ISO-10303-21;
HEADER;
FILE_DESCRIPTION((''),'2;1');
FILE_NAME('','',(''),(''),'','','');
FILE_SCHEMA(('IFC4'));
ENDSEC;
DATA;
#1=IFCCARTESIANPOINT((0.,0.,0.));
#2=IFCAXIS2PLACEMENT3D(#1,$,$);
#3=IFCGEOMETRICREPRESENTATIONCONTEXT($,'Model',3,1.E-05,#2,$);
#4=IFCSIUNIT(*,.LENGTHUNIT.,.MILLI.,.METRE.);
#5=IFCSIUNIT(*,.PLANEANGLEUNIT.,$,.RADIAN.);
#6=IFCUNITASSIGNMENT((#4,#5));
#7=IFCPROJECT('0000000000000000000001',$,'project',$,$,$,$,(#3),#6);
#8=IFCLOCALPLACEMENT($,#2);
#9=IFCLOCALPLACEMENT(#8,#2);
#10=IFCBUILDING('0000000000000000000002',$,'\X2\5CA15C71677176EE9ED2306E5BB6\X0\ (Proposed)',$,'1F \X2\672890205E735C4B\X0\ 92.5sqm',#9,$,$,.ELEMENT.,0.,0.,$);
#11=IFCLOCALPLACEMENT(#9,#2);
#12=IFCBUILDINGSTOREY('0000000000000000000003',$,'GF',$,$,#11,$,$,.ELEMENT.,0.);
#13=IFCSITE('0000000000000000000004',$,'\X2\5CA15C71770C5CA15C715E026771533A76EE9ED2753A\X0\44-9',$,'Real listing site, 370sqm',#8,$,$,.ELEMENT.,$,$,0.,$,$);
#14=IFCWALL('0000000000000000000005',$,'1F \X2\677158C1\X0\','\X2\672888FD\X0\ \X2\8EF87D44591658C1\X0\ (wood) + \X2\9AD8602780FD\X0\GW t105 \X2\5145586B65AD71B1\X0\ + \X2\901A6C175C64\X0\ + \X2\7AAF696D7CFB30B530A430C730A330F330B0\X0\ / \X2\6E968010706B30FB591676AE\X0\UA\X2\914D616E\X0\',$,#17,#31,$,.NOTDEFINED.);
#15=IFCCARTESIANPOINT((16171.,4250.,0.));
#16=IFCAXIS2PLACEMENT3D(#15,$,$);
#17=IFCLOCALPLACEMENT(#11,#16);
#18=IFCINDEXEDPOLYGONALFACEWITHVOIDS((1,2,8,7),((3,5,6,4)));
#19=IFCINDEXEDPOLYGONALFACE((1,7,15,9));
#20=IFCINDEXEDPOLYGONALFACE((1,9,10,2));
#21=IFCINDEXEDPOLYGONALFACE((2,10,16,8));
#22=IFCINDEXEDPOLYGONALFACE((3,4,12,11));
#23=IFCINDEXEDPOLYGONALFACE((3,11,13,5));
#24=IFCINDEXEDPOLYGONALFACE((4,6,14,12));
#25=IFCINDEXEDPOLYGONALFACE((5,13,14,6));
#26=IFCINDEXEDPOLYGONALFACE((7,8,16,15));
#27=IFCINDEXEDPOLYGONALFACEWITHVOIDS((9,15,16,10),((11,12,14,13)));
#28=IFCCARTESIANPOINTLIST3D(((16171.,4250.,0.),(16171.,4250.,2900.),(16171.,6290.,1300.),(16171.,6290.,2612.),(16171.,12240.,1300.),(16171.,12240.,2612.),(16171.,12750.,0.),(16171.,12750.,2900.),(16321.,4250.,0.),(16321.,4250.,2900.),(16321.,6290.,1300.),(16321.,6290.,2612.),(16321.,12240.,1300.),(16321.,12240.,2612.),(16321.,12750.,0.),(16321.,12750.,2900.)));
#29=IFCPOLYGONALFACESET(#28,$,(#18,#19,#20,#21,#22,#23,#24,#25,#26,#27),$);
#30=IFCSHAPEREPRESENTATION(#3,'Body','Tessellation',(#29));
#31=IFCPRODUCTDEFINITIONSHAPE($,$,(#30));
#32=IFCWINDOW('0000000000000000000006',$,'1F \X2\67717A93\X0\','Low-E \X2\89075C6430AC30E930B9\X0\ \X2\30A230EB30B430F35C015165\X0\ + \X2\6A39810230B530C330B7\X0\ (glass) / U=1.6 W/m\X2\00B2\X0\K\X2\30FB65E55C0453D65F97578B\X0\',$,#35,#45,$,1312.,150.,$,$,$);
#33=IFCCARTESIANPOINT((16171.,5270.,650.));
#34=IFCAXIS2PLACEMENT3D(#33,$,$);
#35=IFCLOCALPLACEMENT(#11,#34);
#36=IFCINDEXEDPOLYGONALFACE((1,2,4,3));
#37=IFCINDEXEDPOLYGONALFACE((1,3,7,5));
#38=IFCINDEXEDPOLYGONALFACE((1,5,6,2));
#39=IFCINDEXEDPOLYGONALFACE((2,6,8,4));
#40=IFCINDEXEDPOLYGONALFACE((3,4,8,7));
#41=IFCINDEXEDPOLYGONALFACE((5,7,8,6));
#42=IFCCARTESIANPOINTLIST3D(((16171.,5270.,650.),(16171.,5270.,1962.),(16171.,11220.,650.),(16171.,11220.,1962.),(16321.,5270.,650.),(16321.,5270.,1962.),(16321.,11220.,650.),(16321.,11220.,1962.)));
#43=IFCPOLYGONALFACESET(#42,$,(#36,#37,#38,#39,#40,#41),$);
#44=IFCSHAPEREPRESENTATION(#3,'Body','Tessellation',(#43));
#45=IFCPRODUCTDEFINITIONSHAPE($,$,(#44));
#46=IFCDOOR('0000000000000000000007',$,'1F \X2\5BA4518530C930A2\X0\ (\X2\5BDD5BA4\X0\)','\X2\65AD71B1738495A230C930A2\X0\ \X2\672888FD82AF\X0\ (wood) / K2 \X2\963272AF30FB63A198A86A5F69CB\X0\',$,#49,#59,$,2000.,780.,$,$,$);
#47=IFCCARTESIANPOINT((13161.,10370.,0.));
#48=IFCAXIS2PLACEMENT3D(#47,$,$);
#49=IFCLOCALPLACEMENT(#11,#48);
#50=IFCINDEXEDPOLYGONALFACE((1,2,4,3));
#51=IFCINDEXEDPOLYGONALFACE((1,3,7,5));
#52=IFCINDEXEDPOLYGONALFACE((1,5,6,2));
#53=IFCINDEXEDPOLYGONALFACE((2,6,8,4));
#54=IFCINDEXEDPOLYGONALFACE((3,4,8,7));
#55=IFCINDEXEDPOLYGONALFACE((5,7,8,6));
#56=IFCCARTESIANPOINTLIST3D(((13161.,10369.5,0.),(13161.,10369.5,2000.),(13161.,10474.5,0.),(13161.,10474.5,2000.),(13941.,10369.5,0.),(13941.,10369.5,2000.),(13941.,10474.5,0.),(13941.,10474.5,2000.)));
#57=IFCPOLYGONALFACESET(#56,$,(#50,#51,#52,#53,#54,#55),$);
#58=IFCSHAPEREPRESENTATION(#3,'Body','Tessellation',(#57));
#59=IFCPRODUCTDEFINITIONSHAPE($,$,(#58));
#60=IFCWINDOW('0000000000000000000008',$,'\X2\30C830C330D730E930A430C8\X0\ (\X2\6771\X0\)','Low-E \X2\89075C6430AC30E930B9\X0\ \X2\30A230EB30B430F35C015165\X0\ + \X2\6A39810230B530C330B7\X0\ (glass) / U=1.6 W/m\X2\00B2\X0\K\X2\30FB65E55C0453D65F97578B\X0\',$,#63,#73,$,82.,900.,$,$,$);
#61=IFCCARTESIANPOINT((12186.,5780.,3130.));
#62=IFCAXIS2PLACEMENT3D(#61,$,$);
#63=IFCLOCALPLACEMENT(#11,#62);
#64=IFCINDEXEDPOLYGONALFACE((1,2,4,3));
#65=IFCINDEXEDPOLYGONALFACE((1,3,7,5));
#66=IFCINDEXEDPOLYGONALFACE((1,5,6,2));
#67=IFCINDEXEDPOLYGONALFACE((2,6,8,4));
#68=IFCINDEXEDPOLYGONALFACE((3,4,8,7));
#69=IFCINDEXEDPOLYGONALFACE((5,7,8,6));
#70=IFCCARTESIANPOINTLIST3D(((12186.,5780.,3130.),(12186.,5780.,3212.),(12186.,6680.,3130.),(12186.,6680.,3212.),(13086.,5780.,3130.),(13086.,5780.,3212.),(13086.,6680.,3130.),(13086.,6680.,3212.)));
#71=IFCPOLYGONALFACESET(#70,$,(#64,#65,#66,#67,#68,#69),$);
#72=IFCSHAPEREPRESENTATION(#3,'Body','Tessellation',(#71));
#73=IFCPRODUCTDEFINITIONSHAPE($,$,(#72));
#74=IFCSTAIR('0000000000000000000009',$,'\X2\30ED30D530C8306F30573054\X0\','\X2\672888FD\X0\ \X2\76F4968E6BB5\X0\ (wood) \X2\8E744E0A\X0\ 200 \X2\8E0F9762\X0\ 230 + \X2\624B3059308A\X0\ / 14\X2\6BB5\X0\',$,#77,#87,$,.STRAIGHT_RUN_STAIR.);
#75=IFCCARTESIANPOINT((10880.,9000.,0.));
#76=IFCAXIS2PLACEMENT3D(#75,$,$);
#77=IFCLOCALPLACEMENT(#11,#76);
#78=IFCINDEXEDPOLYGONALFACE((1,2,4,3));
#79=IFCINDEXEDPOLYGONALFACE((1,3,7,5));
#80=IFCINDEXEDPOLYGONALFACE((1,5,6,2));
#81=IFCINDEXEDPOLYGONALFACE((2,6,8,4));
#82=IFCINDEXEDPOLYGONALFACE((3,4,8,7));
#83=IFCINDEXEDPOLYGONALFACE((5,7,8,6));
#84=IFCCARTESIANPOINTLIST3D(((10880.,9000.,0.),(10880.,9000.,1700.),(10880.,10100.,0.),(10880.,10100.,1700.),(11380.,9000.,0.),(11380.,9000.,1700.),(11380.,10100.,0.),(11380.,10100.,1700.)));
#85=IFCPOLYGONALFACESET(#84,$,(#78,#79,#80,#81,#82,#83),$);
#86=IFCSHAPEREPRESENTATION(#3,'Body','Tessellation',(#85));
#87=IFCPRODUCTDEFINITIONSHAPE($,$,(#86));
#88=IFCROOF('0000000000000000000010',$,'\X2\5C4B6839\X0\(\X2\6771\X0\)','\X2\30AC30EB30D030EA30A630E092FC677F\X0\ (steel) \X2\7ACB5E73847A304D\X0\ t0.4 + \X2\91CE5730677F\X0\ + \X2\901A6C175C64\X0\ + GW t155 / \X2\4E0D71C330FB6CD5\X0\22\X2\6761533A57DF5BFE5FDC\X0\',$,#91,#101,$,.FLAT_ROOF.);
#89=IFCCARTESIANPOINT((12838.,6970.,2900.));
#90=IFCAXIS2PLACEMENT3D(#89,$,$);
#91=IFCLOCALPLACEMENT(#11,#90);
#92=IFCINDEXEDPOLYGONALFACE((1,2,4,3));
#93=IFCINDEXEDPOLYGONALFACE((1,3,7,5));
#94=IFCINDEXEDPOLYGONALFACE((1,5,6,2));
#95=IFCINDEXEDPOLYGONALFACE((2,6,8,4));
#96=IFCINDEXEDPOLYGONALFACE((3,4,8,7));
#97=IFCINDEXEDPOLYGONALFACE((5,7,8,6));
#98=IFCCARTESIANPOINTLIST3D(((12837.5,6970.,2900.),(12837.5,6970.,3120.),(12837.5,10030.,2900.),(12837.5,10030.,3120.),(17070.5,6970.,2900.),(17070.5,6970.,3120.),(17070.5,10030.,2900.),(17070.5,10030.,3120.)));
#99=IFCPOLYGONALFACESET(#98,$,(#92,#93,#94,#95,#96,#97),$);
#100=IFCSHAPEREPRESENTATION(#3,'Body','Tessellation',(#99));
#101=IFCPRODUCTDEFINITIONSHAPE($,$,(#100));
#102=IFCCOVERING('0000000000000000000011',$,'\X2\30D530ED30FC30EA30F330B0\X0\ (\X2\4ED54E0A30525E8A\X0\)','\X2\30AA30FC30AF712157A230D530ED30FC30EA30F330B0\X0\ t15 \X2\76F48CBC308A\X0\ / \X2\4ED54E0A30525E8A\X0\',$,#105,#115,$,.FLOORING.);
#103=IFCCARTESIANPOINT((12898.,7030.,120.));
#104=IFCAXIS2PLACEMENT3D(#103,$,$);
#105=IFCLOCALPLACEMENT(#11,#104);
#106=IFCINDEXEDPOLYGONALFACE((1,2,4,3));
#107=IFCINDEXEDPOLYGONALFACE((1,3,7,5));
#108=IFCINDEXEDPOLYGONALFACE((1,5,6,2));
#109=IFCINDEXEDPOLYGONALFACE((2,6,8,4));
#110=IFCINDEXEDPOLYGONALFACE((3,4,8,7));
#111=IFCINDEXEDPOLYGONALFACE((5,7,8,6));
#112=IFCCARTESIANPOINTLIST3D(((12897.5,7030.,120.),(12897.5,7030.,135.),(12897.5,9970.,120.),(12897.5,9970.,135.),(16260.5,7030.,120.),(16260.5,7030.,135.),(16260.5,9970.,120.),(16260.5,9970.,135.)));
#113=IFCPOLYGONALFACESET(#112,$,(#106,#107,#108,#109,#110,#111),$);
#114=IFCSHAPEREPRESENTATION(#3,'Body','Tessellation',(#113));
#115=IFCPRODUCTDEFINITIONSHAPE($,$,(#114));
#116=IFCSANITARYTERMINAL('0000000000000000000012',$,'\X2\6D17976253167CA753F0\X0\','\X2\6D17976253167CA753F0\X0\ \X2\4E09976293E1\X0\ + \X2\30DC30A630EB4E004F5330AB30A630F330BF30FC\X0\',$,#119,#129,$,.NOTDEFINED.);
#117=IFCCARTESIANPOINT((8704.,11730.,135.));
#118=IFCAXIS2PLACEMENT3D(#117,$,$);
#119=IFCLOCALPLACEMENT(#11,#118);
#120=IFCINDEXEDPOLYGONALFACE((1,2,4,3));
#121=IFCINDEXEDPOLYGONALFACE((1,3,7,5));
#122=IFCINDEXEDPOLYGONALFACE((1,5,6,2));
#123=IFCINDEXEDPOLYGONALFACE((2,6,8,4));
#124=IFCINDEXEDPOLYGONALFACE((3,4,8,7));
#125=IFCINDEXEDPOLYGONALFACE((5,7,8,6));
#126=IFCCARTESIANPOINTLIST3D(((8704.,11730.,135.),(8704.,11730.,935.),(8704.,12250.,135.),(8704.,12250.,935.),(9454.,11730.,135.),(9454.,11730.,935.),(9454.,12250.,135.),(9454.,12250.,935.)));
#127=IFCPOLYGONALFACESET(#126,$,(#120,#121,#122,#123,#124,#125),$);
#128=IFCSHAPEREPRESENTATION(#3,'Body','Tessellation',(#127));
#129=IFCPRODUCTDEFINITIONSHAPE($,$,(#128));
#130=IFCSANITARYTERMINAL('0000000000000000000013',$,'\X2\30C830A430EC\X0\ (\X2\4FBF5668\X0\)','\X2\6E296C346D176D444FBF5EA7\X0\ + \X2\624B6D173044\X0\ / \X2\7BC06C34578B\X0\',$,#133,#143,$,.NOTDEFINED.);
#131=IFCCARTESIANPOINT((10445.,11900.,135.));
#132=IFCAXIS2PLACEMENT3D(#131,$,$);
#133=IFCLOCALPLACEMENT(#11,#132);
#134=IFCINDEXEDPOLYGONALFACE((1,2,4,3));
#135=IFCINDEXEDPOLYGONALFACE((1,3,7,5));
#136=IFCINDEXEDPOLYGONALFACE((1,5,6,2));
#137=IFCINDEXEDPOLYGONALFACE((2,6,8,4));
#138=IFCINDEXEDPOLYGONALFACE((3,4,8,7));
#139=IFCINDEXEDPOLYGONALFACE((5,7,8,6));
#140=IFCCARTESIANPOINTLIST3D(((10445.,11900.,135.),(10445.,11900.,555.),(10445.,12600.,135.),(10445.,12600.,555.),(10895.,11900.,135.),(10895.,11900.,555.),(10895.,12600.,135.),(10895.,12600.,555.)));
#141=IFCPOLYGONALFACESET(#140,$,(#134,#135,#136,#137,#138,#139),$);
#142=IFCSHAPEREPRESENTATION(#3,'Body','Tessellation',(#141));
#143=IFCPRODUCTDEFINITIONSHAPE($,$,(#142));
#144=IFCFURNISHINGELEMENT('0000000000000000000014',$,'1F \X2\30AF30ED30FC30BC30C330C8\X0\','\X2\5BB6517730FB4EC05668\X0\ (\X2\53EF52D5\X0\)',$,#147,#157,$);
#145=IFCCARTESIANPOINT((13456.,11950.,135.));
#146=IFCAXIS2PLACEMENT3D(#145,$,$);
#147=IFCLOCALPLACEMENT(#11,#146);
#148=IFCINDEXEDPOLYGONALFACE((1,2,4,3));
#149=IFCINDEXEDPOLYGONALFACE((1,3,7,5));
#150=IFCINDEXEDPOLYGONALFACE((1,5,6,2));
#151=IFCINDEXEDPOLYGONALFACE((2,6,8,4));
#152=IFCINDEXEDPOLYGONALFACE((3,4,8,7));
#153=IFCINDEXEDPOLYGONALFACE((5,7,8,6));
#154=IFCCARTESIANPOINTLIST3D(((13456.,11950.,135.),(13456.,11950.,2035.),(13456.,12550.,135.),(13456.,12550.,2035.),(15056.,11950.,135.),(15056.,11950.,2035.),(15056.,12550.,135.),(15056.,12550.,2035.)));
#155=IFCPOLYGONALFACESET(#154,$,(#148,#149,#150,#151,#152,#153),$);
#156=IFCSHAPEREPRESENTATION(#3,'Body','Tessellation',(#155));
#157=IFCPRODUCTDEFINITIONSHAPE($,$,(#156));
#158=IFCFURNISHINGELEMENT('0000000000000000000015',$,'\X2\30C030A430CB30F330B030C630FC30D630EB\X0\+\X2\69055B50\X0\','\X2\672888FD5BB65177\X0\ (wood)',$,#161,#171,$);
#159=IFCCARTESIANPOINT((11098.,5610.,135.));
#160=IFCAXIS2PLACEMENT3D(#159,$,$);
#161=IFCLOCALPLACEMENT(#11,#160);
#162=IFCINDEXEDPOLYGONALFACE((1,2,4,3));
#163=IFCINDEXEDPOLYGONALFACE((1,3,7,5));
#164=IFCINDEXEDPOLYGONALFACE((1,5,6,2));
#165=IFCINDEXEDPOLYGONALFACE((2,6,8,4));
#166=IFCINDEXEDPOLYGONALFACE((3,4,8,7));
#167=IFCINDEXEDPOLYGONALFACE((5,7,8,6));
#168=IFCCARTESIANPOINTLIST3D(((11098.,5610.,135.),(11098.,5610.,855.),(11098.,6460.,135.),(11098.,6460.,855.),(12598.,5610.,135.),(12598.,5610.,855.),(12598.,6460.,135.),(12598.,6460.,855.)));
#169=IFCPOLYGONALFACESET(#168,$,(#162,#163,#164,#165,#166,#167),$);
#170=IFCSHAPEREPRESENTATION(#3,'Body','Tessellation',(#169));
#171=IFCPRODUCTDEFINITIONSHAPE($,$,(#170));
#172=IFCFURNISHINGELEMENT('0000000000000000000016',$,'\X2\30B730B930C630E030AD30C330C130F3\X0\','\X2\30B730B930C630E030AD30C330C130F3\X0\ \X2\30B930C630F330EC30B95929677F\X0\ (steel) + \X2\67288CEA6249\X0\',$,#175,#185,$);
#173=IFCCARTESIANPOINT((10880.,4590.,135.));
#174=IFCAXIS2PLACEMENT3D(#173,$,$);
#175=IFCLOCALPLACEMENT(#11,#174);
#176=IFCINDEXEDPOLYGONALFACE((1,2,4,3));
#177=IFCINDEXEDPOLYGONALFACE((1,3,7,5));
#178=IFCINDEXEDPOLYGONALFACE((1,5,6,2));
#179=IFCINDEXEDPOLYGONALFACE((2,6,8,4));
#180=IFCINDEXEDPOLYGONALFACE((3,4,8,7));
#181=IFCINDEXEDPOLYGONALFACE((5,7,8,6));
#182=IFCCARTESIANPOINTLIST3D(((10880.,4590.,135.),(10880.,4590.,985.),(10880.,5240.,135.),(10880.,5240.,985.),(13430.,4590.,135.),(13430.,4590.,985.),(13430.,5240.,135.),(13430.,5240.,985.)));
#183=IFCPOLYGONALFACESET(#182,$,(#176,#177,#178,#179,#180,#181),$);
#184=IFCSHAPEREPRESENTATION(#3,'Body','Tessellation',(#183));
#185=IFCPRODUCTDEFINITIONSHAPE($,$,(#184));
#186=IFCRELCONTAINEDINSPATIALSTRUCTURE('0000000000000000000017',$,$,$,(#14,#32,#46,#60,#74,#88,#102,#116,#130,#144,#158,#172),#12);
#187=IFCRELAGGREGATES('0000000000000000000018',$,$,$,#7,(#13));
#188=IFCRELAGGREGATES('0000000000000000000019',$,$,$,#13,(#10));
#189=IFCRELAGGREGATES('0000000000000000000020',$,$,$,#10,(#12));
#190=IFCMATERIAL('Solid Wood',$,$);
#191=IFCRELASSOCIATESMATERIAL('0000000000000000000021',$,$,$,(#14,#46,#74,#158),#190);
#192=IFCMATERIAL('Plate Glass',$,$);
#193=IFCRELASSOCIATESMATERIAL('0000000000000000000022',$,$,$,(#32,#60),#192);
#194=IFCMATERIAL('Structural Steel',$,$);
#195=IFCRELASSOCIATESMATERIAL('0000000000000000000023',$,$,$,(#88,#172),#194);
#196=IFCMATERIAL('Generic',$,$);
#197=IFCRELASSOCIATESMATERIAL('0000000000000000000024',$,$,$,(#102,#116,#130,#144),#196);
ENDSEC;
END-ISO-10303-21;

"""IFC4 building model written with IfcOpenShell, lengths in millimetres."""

from ifc_helpers import new_model, si_unit, frame, frame_2d, origin, place, context, project, spatial, rectangle, extrude, material, element, fill, save


model = new_model("IFC4")

# Units and contexts
model_context = context("Model", 3, precision=1e-05, world=origin())
ifc_project = project(units=[si_unit("LENGTHUNIT", "METRE", prefix="MILLI"), si_unit("PLANEANGLEUNIT", "RADIAN")], contexts=[model_context])

# Site, building, storey
site_placement = place(None, origin())
site = spatial("IfcSite", under=ifc_project, at=site_placement, Name="岡山県岡山市東区目黒町44-9", ObjectType="Real listing site, 370sqm", CompositionType="ELEMENT", RefElevation=0.0)
building_placement = place(site_placement, origin())
building = spatial("IfcBuilding", under=site, at=building_placement, Name="岡山東目黒の家 (Proposed)", ObjectType="1F 木造平屋 92.5sqm", CompositionType="ELEMENT", ElevationOfRefHeight=0.0, ElevationOfTerrain=0.0)
storey_placement = place(building_placement, origin())
storey = spatial("IfcBuildingStorey", under=building, at=storey_placement, Name="GF", CompositionType="ELEMENT", Elevation=0.0)

# Shared definitions
ifc_material_1 = material(Name="Solid Wood")

# Wall, opening, window
wall_1_placement = place(storey_placement, frame((16171.0, 4250.0, 0.0)))
wall_1 = element("IfcWall", 1, at=wall_1_placement, inside=storey, material=ifc_material_1, Name="1F 東壁", Description="木製 軸組外壁 (wood) + 高性能GW t105 充填断熱 + 通気層 + 窯業系サイディング / 準耐火・外皮UA配慮", PredefinedType="NOTDEFINED", context=model_context, shape_type="SweptSolid", body=[
    extrude(rectangle(XDim=150.0, YDim=8500.0, at=frame_2d((75.0, 4250.0))), frame((16171.0, 4250.0, 0.0)), (0.0, 0.0, 1.0), 2900.0),
])
opening_1_placement = place(storey_placement, frame((16171.0, 5270.0, 650.0)))
opening_1 = element("IfcOpeningElement", 2, at=opening_1_placement, cuts=wall_1, PredefinedType="NOTDEFINED", context=model_context, shape_type="SweptSolid", body=[
    extrude(rectangle(XDim=150.0, YDim=5950.0, at=frame_2d((75.0, 2975.0))), frame((16171.0, 5270.0, 650.0)), (0.0, 0.0, 1.0), 1312.0),
])
ifc_material_2 = material(Name="Plate Glass")
window_1_placement = place(storey_placement, frame((16171.0, 5270.0, 650.0)))
window_1 = element("IfcWindow", 3, at=window_1_placement, inside=storey, material=ifc_material_2, Name="1F 東窓", Description="Low-E 複層ガラス アルゴン封入 + 樹脂サッシ (glass) / U=1.6 W/m²K・日射取得型", OverallHeight=1312.0, OverallWidth=150.0, context=model_context, shape_type="SweptSolid", body=[
    extrude(rectangle(XDim=150.0, YDim=5950.0, at=frame_2d((75.0, 2975.0))), frame((16171.0, 5270.0, 650.0)), (0.0, 0.0, 1.0), 1312.0),
])
fill(opening_1, window_1)

# Door
door_placement = place(storey_placement, frame((13161.0, 10370.0, 0.0)))
element("IfcDoor", 4, at=door_placement, inside=storey, material=ifc_material_1, Name="1F 室内ドア (寝室)", Description="断熱玄関ドア 木製芯 (wood) / K2 防犯・採風機構", OverallHeight=2000.0, OverallWidth=780.0, context=model_context, shape_type="SweptSolid", body=[
    extrude(rectangle(XDim=780.0, YDim=105.0, at=frame_2d((390.0, 52.0))), frame((13161.0, 10370.0, 0.0)), (0.0, 0.0, 1.0), 2000.0),
])

# Window
window_2_placement = place(storey_placement, frame((12186.0, 5780.0, 3130.0)))
element("IfcWindow", 5, at=window_2_placement, inside=storey, material=ifc_material_2, Name="トップライト (東)", Description="Low-E 複層ガラス アルゴン封入 + 樹脂サッシ (glass) / U=1.6 W/m²K・日射取得型", OverallHeight=82.0, OverallWidth=900.0, context=model_context, shape_type="SweptSolid", body=[
    extrude(rectangle(XDim=900.0, YDim=900.0, at=frame_2d((450.0, 450.0))), frame((12186.0, 5780.0, 3130.0)), (0.0, 0.0, 1.0), 82.0),
])

# Stair
stair_placement = place(storey_placement, frame((10880.0, 9000.0, 0.0)))
element("IfcStair", 6, at=stair_placement, inside=storey, material=ifc_material_1, Name="ロフトはしご", Description="木製 直階段 (wood) 蹴上 200 踏面 230 + 手すり / 14段", PredefinedType="STRAIGHT_RUN_STAIR", context=model_context, shape_type="SweptSolid", body=[
    extrude(rectangle(XDim=500.0, YDim=1100.0, at=frame_2d((250.0, 550.0))), frame((10880.0, 9000.0, 0.0)), (0.0, 0.0, 1.0), 1700.0),
])

# Roof
ifc_material_3 = material(Name="Structural Steel")
roof_placement = place(storey_placement, frame((12838.0, 6970.0, 2900.0)))
element("IfcRoof", 7, at=roof_placement, inside=storey, material=ifc_material_3, Name="屋根(東)", Description="ガルバリウム鋼板 (steel) 立平葺き t0.4 + 野地板 + 通気層 + GW t155 / 不燃・法22条区域対応", PredefinedType="FLAT_ROOF", context=model_context, shape_type="SweptSolid", body=[
    extrude(rectangle(XDim=4233.0, YDim=3060.0, at=frame_2d((2116.0, 1530.0))), frame((12838.0, 6970.0, 2900.0)), (0.0, 0.0, 1.0), 220.0),
])

# Covering
ifc_material_4 = material(Name="Generic")
covering_placement = place(storey_placement, frame((12898.0, 7030.0, 120.0)))
element("IfcCovering", 8, at=covering_placement, inside=storey, material=ifc_material_4, Name="フローリング (仕上げ床)", Description="オーク無垢フローリング t15 直貼り / 仕上げ床", PredefinedType="FLOORING", context=model_context, shape_type="SweptSolid", body=[
    extrude(rectangle(XDim=3363.0, YDim=2940.0, at=frame_2d((1681.0, 1470.0))), frame((12898.0, 7030.0, 120.0)), (0.0, 0.0, 1.0), 15.0),
])

# Sanitary terminals
sanitary_terminal_1_placement = place(storey_placement, frame((8704.0, 11730.0, 135.0)))
element("IfcSanitaryTerminal", 9, at=sanitary_terminal_1_placement, inside=storey, material=ifc_material_4, Name="洗面化粧台", Description="洗面化粧台 三面鏡 + ボウル一体カウンター", PredefinedType="NOTDEFINED", context=model_context, shape_type="SweptSolid", body=[
    extrude(rectangle(XDim=750.0, YDim=520.0, at=frame_2d((375.0, 260.0))), frame((8704.0, 11730.0, 135.0)), (0.0, 0.0, 1.0), 800.0),
])
sanitary_terminal_2_placement = place(storey_placement, frame((10445.0, 11900.0, 135.0)))
element("IfcSanitaryTerminal", 10, at=sanitary_terminal_2_placement, inside=storey, material=ifc_material_4, Name="トイレ (便器)", Description="温水洗浄便座 + 手洗い / 節水型", PredefinedType="NOTDEFINED", context=model_context, shape_type="SweptSolid", body=[
    extrude(rectangle(XDim=450.0, YDim=700.0, at=frame_2d((225.0, 350.0))), frame((10445.0, 11900.0, 135.0)), (0.0, 0.0, 1.0), 420.0),
])

# Furnishing elements
furnishing_1_placement = place(storey_placement, frame((13456.0, 11950.0, 135.0)))
element("IfcFurnishingElement", 11, at=furnishing_1_placement, inside=storey, material=ifc_material_4, Name="1F クローゼット", Description="家具・什器 (可動)", context=model_context, shape_type="SweptSolid", body=[
    extrude(rectangle(XDim=1600.0, YDim=600.0, at=frame_2d((800.0, 300.0))), frame((13456.0, 11950.0, 135.0)), (0.0, 0.0, 1.0), 1900.0),
])
furnishing_2_placement = place(storey_placement, frame((11098.0, 5610.0, 135.0)))
element("IfcFurnishingElement", 12, at=furnishing_2_placement, inside=storey, material=ifc_material_1, Name="ダイニングテーブル+椅子", Description="木製家具 (wood)", context=model_context, shape_type="SweptSolid", body=[
    extrude(rectangle(XDim=1500.0, YDim=850.0, at=frame_2d((750.0, 425.0))), frame((11098.0, 5610.0, 135.0)), (0.0, 0.0, 1.0), 720.0),
])
furnishing_3_placement = place(storey_placement, frame((10880.0, 4590.0, 135.0)))
element("IfcFurnishingElement", 13, at=furnishing_3_placement, inside=storey, material=ifc_material_3, Name="システムキッチン", Description="システムキッチン ステンレス天板 (steel) + 木質扉", context=model_context, shape_type="SweptSolid", body=[
    extrude(rectangle(XDim=2550.0, YDim=650.0, at=frame_2d((1275.0, 325.0))), frame((10880.0, 4590.0, 135.0)), (0.0, 0.0, 1.0), 850.0),
])

save(model, "model.ifc")
